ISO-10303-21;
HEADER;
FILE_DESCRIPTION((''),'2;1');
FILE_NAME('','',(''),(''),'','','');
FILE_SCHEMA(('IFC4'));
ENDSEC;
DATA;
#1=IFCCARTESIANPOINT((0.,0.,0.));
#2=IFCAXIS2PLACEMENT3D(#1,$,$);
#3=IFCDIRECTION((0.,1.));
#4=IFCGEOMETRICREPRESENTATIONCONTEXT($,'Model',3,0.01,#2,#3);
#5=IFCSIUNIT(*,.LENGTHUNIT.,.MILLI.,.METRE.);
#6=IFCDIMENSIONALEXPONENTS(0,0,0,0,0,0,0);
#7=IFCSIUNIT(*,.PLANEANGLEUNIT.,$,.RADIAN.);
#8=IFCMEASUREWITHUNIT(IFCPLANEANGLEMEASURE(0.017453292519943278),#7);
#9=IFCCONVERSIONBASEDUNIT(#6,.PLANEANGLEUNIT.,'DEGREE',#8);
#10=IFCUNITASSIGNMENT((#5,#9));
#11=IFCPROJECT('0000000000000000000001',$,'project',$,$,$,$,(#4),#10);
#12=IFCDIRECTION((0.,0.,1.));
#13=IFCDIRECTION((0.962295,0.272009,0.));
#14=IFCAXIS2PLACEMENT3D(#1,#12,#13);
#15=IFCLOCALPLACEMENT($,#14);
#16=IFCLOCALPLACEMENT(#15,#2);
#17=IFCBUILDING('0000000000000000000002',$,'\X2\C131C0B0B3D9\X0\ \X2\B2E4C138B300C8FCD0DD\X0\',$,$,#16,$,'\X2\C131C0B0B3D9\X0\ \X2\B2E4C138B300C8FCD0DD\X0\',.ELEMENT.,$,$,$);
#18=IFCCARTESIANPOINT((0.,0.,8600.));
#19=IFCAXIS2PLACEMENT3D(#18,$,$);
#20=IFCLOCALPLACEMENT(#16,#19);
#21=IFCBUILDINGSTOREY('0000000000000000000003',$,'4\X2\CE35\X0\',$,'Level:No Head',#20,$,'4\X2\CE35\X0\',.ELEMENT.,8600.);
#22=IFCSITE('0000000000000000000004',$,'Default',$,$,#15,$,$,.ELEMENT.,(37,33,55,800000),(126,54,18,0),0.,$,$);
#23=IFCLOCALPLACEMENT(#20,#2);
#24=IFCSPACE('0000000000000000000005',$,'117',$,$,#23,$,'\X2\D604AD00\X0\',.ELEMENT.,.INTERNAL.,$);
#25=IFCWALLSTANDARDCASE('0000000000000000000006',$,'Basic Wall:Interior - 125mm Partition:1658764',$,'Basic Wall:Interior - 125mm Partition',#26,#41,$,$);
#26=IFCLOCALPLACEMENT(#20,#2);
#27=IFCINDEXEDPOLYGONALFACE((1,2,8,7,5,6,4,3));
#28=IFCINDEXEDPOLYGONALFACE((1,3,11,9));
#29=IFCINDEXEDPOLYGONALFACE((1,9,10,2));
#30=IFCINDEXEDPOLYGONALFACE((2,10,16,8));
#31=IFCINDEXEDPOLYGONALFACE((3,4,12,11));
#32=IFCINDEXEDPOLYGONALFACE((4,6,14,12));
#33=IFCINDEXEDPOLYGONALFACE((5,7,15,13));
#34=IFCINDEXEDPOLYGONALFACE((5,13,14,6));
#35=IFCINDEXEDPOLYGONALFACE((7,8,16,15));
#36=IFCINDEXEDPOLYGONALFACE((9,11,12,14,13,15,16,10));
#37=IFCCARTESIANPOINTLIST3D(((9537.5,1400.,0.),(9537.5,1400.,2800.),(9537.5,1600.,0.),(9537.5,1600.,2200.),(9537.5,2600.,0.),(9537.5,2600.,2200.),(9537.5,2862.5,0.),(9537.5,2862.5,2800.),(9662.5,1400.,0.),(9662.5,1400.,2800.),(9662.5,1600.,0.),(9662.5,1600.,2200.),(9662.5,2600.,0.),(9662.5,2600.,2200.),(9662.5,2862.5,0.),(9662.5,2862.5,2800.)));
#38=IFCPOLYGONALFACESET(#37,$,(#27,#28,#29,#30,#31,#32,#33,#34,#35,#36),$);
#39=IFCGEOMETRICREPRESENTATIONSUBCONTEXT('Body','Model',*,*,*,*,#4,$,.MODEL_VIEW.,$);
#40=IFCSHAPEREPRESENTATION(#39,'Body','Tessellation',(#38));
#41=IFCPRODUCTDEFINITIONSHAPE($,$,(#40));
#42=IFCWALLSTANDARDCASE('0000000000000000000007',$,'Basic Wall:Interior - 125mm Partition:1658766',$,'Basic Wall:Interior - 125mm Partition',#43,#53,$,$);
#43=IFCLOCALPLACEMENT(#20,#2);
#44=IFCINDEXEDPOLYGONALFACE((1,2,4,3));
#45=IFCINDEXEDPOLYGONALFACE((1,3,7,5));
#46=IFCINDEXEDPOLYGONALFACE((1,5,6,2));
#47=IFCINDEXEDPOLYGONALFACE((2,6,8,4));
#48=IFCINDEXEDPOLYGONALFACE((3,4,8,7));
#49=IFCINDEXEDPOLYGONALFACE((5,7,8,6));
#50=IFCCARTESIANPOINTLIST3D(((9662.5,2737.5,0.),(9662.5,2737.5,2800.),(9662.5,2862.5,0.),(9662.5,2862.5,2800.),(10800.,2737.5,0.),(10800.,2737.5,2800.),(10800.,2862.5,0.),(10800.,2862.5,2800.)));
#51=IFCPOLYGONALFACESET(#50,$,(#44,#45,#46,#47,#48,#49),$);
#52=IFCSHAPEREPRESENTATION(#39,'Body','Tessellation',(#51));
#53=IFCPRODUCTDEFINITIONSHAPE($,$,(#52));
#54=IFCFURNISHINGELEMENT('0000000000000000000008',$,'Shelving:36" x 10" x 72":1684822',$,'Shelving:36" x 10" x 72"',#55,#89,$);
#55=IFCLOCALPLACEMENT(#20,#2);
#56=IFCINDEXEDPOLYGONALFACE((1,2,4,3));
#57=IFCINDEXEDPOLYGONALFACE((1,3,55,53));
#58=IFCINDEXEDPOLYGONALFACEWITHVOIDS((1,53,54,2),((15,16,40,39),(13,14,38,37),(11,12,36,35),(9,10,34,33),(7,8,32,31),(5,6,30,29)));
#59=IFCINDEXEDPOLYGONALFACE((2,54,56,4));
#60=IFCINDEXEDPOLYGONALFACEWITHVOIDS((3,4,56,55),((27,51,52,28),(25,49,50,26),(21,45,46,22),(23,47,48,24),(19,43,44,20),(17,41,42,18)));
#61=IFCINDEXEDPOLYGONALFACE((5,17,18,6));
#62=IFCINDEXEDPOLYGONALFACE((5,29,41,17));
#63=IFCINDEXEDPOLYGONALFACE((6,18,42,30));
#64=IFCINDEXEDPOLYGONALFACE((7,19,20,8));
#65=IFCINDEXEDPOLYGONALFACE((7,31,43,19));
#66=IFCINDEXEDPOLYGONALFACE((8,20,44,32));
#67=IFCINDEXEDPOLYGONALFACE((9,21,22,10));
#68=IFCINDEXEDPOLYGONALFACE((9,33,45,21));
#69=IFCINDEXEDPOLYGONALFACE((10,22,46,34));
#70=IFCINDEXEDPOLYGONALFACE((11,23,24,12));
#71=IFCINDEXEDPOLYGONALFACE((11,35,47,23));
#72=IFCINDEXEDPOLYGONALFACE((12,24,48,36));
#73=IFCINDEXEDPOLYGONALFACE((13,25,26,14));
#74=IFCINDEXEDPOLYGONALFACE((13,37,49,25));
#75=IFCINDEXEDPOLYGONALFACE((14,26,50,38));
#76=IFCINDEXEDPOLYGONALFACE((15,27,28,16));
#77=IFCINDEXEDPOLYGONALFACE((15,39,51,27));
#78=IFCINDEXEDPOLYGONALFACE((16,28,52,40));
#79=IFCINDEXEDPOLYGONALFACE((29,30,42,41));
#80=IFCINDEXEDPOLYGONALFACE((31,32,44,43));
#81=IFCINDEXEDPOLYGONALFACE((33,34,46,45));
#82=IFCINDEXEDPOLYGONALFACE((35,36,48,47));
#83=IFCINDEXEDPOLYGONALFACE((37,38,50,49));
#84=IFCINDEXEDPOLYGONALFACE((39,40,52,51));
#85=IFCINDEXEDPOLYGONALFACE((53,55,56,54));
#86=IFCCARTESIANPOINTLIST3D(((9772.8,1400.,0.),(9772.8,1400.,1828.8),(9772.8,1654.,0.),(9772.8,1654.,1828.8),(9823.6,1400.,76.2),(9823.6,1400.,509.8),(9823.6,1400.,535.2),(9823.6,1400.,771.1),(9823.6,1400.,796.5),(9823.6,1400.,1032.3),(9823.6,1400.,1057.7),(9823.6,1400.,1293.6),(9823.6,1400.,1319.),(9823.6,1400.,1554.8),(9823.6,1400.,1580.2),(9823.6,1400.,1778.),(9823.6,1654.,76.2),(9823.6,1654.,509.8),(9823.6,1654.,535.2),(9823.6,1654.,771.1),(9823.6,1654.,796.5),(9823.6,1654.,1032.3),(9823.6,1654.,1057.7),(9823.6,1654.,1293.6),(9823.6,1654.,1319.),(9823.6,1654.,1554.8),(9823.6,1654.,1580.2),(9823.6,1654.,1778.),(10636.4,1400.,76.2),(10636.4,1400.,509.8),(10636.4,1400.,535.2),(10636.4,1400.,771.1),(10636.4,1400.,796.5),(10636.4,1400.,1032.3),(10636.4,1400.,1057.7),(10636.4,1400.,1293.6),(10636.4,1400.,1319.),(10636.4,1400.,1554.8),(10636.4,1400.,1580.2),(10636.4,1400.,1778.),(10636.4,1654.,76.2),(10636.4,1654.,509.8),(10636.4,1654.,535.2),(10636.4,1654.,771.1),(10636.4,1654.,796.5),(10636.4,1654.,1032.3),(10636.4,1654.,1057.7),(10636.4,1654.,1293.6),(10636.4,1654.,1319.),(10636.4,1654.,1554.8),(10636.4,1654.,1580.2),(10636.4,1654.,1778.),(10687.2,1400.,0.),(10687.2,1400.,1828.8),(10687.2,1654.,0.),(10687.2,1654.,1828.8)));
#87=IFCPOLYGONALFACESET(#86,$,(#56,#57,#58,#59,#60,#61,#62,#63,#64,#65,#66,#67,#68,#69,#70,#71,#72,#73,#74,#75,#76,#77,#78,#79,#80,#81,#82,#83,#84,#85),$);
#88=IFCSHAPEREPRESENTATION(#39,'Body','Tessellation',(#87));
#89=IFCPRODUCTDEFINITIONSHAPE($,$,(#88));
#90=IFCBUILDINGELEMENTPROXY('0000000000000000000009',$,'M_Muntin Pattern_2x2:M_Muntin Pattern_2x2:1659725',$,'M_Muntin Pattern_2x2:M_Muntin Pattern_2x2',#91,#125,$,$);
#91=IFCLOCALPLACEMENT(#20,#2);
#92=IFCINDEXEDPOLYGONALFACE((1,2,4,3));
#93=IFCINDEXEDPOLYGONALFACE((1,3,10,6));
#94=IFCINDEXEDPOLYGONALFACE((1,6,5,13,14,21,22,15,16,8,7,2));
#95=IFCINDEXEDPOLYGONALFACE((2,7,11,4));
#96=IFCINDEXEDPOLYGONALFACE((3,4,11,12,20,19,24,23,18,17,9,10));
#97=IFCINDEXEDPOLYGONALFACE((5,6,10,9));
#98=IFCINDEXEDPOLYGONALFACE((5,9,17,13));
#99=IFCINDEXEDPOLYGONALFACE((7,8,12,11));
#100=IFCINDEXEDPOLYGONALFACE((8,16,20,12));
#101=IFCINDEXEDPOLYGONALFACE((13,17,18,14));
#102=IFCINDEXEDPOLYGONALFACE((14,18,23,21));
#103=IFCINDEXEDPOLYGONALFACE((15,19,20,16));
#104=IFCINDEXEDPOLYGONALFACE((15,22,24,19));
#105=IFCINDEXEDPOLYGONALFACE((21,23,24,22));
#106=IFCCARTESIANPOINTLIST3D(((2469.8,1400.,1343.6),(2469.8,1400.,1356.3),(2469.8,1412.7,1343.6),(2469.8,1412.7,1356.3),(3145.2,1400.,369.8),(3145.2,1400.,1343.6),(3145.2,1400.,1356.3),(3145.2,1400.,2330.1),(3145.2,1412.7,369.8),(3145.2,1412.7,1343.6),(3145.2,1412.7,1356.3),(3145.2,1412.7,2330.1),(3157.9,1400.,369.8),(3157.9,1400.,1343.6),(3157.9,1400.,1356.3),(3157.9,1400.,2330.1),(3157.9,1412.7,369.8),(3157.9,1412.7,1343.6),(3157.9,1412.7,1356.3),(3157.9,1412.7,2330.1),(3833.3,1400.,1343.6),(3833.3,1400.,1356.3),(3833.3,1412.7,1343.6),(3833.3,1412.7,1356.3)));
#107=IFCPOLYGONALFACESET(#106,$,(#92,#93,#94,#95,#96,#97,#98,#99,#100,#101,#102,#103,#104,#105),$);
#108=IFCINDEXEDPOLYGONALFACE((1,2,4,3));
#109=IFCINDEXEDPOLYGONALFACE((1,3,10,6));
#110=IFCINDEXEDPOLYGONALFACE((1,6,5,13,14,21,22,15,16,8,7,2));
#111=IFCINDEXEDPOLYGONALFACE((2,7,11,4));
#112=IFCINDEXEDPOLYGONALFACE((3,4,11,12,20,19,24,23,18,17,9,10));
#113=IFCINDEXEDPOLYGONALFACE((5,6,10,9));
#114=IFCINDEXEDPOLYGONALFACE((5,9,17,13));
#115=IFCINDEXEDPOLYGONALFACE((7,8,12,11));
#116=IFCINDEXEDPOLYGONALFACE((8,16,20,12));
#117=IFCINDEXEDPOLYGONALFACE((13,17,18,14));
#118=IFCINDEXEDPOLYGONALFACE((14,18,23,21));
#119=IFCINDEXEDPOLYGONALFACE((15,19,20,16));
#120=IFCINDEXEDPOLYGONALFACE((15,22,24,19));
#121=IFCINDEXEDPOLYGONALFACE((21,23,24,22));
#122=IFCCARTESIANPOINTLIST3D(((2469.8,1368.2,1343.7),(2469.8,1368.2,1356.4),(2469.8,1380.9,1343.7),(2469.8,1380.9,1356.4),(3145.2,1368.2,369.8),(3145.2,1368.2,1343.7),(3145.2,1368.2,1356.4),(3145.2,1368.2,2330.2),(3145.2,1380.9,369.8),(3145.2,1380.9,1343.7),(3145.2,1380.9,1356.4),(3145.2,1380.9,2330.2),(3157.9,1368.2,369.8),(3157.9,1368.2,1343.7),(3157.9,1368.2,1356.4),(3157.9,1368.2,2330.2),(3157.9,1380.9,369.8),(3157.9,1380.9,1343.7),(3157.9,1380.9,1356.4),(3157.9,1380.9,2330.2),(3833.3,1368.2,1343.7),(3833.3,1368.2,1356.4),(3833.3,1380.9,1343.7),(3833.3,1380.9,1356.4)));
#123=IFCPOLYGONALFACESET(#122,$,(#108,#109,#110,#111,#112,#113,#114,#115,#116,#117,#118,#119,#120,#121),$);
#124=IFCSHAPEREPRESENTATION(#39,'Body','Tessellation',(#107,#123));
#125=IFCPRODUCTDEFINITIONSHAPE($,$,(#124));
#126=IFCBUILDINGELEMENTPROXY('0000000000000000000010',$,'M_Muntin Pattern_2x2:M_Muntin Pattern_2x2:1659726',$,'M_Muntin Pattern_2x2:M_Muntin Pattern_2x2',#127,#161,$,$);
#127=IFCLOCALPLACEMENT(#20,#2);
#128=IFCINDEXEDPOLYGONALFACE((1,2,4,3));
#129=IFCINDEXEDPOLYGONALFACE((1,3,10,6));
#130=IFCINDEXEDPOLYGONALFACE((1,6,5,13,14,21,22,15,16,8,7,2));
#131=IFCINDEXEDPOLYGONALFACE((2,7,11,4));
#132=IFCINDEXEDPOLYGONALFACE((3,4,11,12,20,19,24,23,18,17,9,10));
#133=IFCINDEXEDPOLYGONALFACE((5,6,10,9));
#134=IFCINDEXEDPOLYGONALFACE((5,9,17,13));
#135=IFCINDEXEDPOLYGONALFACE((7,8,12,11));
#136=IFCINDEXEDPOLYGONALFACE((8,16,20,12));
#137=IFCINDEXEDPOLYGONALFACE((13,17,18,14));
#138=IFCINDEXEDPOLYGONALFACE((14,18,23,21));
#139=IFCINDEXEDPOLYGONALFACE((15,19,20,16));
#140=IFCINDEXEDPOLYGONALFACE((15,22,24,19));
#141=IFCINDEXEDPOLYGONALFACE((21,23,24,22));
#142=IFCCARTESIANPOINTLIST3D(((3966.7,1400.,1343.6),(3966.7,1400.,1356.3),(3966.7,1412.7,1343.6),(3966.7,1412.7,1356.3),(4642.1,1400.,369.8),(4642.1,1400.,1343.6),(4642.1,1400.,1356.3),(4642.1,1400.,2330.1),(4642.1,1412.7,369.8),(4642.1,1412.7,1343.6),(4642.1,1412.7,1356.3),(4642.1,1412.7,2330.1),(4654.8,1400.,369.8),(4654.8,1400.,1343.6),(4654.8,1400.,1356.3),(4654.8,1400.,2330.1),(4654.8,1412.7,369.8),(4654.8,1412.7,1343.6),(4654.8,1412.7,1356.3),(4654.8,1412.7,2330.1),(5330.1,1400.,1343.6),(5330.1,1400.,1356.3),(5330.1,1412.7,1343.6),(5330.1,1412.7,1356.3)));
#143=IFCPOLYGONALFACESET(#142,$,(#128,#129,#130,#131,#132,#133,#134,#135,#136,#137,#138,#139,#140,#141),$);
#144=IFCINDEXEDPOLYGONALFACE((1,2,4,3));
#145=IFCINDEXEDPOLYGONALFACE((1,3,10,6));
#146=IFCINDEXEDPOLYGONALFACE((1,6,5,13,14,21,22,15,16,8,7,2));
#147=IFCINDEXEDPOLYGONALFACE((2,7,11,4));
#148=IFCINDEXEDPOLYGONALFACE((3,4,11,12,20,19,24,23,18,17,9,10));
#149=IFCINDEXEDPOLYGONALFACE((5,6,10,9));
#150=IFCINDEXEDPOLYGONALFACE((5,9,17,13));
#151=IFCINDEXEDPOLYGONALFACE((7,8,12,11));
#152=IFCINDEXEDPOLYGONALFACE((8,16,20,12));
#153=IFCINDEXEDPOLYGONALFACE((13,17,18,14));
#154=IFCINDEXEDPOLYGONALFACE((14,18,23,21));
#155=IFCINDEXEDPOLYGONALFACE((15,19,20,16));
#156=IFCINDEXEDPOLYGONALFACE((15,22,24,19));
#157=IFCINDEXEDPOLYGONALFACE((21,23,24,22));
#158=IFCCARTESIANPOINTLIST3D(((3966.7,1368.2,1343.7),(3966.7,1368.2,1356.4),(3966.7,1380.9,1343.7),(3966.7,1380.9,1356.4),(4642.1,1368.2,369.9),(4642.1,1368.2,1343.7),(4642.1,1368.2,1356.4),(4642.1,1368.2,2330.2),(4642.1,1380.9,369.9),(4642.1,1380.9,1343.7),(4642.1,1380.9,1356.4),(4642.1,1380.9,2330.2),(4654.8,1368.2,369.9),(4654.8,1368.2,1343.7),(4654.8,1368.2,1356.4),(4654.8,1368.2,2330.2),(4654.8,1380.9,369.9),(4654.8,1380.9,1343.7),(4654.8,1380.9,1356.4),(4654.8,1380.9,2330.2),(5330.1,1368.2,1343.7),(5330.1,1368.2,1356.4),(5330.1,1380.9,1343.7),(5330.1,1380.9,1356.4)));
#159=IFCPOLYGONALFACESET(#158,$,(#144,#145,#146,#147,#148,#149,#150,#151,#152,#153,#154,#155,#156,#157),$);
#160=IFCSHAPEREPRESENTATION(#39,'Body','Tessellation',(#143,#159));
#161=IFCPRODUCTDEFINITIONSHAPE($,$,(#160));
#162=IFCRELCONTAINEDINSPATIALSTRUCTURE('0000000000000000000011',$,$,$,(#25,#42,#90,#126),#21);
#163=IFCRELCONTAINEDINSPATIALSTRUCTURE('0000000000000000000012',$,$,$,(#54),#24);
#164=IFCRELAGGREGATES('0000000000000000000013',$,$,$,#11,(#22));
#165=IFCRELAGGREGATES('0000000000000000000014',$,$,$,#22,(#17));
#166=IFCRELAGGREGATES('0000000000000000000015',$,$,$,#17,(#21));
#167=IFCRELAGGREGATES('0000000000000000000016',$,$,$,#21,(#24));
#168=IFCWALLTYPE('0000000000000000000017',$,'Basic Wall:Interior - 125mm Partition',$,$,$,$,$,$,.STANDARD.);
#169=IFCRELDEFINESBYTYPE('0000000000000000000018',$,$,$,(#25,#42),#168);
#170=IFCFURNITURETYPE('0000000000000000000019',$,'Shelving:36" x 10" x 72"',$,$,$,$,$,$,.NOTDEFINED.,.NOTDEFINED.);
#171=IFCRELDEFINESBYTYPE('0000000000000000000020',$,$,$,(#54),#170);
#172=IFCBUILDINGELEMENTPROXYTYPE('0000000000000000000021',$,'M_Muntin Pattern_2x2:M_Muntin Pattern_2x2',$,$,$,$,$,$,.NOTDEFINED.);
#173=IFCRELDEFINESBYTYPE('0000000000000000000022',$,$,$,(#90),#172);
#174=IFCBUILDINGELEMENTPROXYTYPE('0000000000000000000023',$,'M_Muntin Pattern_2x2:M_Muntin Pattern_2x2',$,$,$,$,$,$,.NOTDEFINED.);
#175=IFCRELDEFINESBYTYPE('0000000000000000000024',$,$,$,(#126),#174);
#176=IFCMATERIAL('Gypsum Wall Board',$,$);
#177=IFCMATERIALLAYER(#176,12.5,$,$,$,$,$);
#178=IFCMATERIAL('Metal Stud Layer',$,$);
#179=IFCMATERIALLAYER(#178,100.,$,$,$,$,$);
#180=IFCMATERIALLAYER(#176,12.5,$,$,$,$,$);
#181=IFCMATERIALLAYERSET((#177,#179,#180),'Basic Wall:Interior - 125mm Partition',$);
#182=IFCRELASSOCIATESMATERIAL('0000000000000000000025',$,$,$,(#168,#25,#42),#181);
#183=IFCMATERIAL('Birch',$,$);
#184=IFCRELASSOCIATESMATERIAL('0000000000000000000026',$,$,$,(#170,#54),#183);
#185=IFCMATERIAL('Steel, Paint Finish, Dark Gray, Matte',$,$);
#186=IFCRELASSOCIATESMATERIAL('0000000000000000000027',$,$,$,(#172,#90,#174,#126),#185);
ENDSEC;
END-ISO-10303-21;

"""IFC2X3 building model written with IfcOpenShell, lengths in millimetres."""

from ifc_helpers import new_model, entity, si_unit, converted_unit, direction, frame, frame_2d, origin, place, context, subcontext, project, spatial, polyline, rectangle, outline, extrude, source, transform, mapped, material, layer, layer_set, layer_usage, type_object, type_shapes, element, save


model = new_model("IFC2X3")

# Units and contexts
model_context = context("Model", 3, precision=0.01, world=origin(), true_north=direction((0.0, 1.0)))
body_context = subcontext(model_context, "Body", "Model", "MODEL_VIEW")
ifc_project = project(units=[si_unit("LENGTHUNIT", "METRE", prefix="MILLI"), converted_unit("PLANEANGLEUNIT", "DEGREE", entity("IfcPlaneAngleMeasure", 0.017453292519943278), si_unit("PLANEANGLEUNIT", "RADIAN"), dimensions=[0, 0, 0, 0, 0, 0, 0])], contexts=[model_context])

# Site, building, storey
site_placement = place(None, frame((0.0, 0.0, 0.0), z_axis=(0.0, 0.0, 1.0), x_axis=(0.962295, 0.272009, 0.0)))
site = spatial("IfcSite", under=ifc_project, at=site_placement, Name="Default", CompositionType="ELEMENT", RefLatitude=(37, 33, 55, 800000), RefLongitude=(126, 54, 18, 0), RefElevation=0.0)
building_placement = place(site_placement, origin())
building = spatial("IfcBuilding", under=site, at=building_placement, Name="성산동 다세대주택", LongName="성산동 다세대주택", CompositionType="ELEMENT")
storey_placement = place(building_placement, frame((0.0, 0.0, 8600.0)))
storey = spatial("IfcBuildingStorey", under=building, at=storey_placement, Name="4층", ObjectType="Level:No Head", LongName="4층", CompositionType="ELEMENT", Elevation=8600.0)

# Shared definitions
ifc_material_1 = material(Name="Steel, Paint Finish, Dark Gray, Matte")
ifc_material_2 = material(Name="Gypsum Wall Board")

# Shared definitions
ifc_layer_1 = layer(ifc_material_2, 12.5)
ifc_material_3 = material(Name="Metal Stud Layer")
ifc_layer_2 = layer(ifc_material_3, 100.0)
ifc_layer_3 = layer(ifc_material_2, 12.5)
ifc_layer_set_1 = layer_set([ifc_layer_1, ifc_layer_2, ifc_layer_3], Name="Basic Wall:Interior - 125mm Partition")
wall_type_1 = type_object("IfcWallType", Name="Basic Wall:Interior - 125mm Partition", PredefinedType="STANDARD", material=ifc_layer_set_1)

# Wall, openings
ifc_layer_usage_1 = layer_usage(ifc_layer_set_1, "AXIS2", "NEGATIVE", 62.5)
wall_1_placement = place(storey_placement, frame((9600.0, 1400.0, 0.0), z_axis=(0.0, 0.0, 1.0), x_axis=(0.0, 1.0, 0.0)))
wall_1 = element("IfcWallStandardCase", 1, at=wall_1_placement, inside=storey, type_object=wall_type_1, material=ifc_layer_usage_1, Name="Basic Wall:Interior - 125mm Partition:1658764", ObjectType="Basic Wall:Interior - 125mm Partition", context=body_context, shape_type="SweptSolid", body=[
    extrude(rectangle(XDim=1462.5, YDim=125.0, at=frame_2d((731.2, 0.0), x_axis=(-1.0, 0.0))), origin(), (0.0, 0.0, 1.0), 2800.0),
])
opening_1_placement = place(wall_1_placement, origin())
element("IfcOpeningElement", 2, at=opening_1_placement, cuts=wall_1, ObjectType="Opening", context=body_context, shape_type="SweptSolid", body=[
    extrude(rectangle(XDim=2200.0, YDim=1000.0, at=frame_2d((0.0, 0.0), x_axis=(0.0, 1.0))), frame((700.0, -1586.5, 3900.0), z_axis=(0.0, 1.0, 0.0), x_axis=(-1.0, 0.0, 0.0)), (0.0, 0.0, 1.0), 3048.0),
])
opening_2_placement = place(wall_1_placement, frame((200.0, -62.5, 0.0)))
element("IfcOpeningElement", 3, at=opening_2_placement, cuts=wall_1, ObjectType="Opening", context=body_context, shape_type="SweptSolid", body=[
    extrude(rectangle(XDim=2200.0, YDim=1000.0, at=frame_2d((1100.0, 500.0), x_axis=(1.0, 0.0))), frame((0.0, 0.0, 0.0), z_axis=(0.0, 1.0, 0.0), x_axis=(0.0, 0.0, 1.0)), (0.0, 0.0, 1.0), 125.0),
])

# Wall
ifc_layer_usage_2 = layer_usage(ifc_layer_set_1, "AXIS2", "NEGATIVE", 62.5)
wall_2_placement = place(storey_placement, frame((9662.5, 2800.0, 0.0)))
element("IfcWallStandardCase", 4, at=wall_2_placement, inside=storey, type_object=wall_type_1, material=ifc_layer_usage_2, Name="Basic Wall:Interior - 125mm Partition:1658766", ObjectType="Basic Wall:Interior - 125mm Partition", context=body_context, shape_type="SweptSolid", body=[
    extrude(rectangle(XDim=1137.5, YDim=125.0, at=frame_2d((568.7, 0.0), x_axis=(-1.0, 0.0))), origin(), (0.0, 0.0, 1.0), 2800.0),
])

# Shared definitions
space_1_placement = place(storey_placement, origin())
space_1 = spatial("IfcSpace", under=storey, at=space_1_placement, Name="117", LongName="현관", CompositionType="ELEMENT", InteriorOrExteriorSpace="INTERNAL")

# Furnishing element
ifc_material_4 = material(Name="Birch")
furniture_type_1 = type_object("IfcFurnitureType", Name="Shelving:36\" x 10\" x 72\"", AssemblyPlace="NOTDEFINED", material=ifc_material_4)
shared_shape_1 = source(origin(), body_context, "Body", "SweptSolid", [
    extrude(outline(polyline([(-457.2, -914.4), (457.2, -914.4), (457.2, 914.4), (-457.2, 914.4), (-457.2, -914.4)]), holes=[polyline([(-406.4, 863.6), (406.4, 863.6), (406.4, 665.8), (-406.4, 665.8), (-406.4, 863.6)]), polyline([(-406.4, -838.2), (-406.4, -404.6), (406.4, -404.6), (406.4, -838.2), (-406.4, -838.2)]), polyline([(406.4, 143.3), (-406.4, 143.3), (-406.4, 379.2), (406.4, 379.2), (406.4, 143.3)]), polyline([(-406.4, 640.4), (406.4, 640.4), (406.4, 404.6), (-406.4, 404.6), (-406.4, 640.4)]), polyline([(-406.4, 117.9), (406.4, 117.9), (406.4, -117.9), (-406.4, -117.9), (-406.4, 117.9)]), polyline([(-406.4, -143.3), (406.4, -143.3), (406.4, -379.2), (-406.4, -379.2), (-406.4, -143.3)])]), frame((0.0, -431.8, 914.4), z_axis=(0.0, 1.0, 0.0), x_axis=(-1.0, 0.0, 0.0)), (0.0, 0.0, 1.0), 254.0),
])
type_shapes(furniture_type_1, [shared_shape_1])
furnishing_1_placement = place(space_1_placement, frame((10230.0, 1222.2, 0.0), z_axis=(0.0, 0.0, 1.0), x_axis=(-1.0, 0.0, 0.0)))
element("IfcFurnishingElement", 5, at=furnishing_1_placement, inside=space_1, type_object=furniture_type_1, material=ifc_material_4, Name="Shelving:36\" x 10\" x 72\":1684822", ObjectType="Shelving:36\" x 10\" x 72\"", context=body_context, shape_type="MappedRepresentation", body=[
    mapped(shared_shape_1, transform((0.0, 0.0, 0.0), scale=1.0)),
])

# Building element proxies
building_element_proxy_type_1 = type_object("IfcBuildingElementProxyType", Name="M_Muntin Pattern_2x2:M_Muntin Pattern_2x2", PredefinedType="NOTDEFINED", material=ifc_material_1)
shared_shape_2 = source(origin(), body_context, "Body", "SweptSolid", [
    extrude(outline(polyline([(6.4, -6.4), (980.1, -6.4), (980.1, 6.3), (6.4, 6.3), (6.4, 681.7), (-6.3, 681.7), (-6.3, 6.3), (-980.2, 6.3), (-980.2, -6.4), (-6.3, -6.4), (-6.3, -681.7), (6.4, -681.7), (6.4, -6.4)])), frame((0.0, 9.5, 980.1), z_axis=(0.0, 1.0, 0.0), x_axis=(0.0, 0.0, 1.0)), (0.0, 0.0, 1.0), 12.7),
    extrude(outline(polyline([(6.4, -6.4), (980.2, -6.4), (980.2, 6.3), (6.4, 6.3), (6.4, 681.7), (-6.3, 681.7), (-6.3, 6.3), (-980.2, 6.3), (-980.2, -6.4), (-6.3, -6.4), (-6.3, -681.7), (6.4, -681.7), (6.4, -6.4)])), frame((0.0, -22.2, 980.2), z_axis=(0.0, 1.0, 0.0), x_axis=(0.0, 0.0, 1.0)), (0.0, 0.0, 1.0), 12.7),
])
type_shapes(building_element_proxy_type_1, [shared_shape_2])
proxy_1_placement = place(storey_placement, frame((3151.6, 1390.5, 369.8)))
element("IfcBuildingElementProxy", 6, at=proxy_1_placement, inside=storey, type_object=building_element_proxy_type_1, material=ifc_material_1, Name="M_Muntin Pattern_2x2:M_Muntin Pattern_2x2:1659725", ObjectType="M_Muntin Pattern_2x2:M_Muntin Pattern_2x2", context=body_context, shape_type="MappedRepresentation", body=[
    mapped(shared_shape_2, transform((0.0, 0.0, 0.0), scale=1.0)),
])
building_element_proxy_type_2 = type_object("IfcBuildingElementProxyType", Name="M_Muntin Pattern_2x2:M_Muntin Pattern_2x2", PredefinedType="NOTDEFINED", material=ifc_material_1)
shared_shape_3 = source(origin(), body_context, "Body", "SweptSolid", [
    extrude(outline(polyline([(6.4, -6.4), (980.1, -6.4), (980.1, 6.3), (6.4, 6.3), (6.4, 681.7), (-6.3, 681.7), (-6.3, 6.3), (-980.2, 6.3), (-980.2, -6.4), (-6.3, -6.4), (-6.3, -681.7), (6.4, -681.7), (6.4, -6.4)])), frame((0.0, -22.2, 980.1), z_axis=(0.0, 1.0, 0.0), x_axis=(0.0, 0.0, 1.0)), (0.0, 0.0, 1.0), 12.7),
    extrude(outline(polyline([(6.4, -6.4), (980.2, -6.4), (980.2, 6.3), (6.4, 6.3), (6.4, 681.7), (-6.3, 681.7), (-6.3, 6.3), (-980.2, 6.3), (-980.2, -6.4), (-6.3, -6.4), (-6.3, -681.7), (6.4, -681.7), (6.4, -6.4)])), frame((0.0, 9.5, 980.2), z_axis=(0.0, 1.0, 0.0), x_axis=(0.0, 0.0, 1.0)), (0.0, 0.0, 1.0), 12.7),
])
type_shapes(building_element_proxy_type_2, [shared_shape_3])
proxy_2_placement = place(storey_placement, frame((4648.4, 1390.5, 369.9), z_axis=(0.0, 0.0, 1.0), x_axis=(-1.0, 0.0, 0.0)))
element("IfcBuildingElementProxy", 7, at=proxy_2_placement, inside=storey, type_object=building_element_proxy_type_2, material=ifc_material_1, Name="M_Muntin Pattern_2x2:M_Muntin Pattern_2x2:1659726", ObjectType="M_Muntin Pattern_2x2:M_Muntin Pattern_2x2", context=body_context, shape_type="MappedRepresentation", body=[
    mapped(shared_shape_3, transform((0.0, 0.0, 0.0), scale=1.0)),
])

save(model, "model.ifc")
